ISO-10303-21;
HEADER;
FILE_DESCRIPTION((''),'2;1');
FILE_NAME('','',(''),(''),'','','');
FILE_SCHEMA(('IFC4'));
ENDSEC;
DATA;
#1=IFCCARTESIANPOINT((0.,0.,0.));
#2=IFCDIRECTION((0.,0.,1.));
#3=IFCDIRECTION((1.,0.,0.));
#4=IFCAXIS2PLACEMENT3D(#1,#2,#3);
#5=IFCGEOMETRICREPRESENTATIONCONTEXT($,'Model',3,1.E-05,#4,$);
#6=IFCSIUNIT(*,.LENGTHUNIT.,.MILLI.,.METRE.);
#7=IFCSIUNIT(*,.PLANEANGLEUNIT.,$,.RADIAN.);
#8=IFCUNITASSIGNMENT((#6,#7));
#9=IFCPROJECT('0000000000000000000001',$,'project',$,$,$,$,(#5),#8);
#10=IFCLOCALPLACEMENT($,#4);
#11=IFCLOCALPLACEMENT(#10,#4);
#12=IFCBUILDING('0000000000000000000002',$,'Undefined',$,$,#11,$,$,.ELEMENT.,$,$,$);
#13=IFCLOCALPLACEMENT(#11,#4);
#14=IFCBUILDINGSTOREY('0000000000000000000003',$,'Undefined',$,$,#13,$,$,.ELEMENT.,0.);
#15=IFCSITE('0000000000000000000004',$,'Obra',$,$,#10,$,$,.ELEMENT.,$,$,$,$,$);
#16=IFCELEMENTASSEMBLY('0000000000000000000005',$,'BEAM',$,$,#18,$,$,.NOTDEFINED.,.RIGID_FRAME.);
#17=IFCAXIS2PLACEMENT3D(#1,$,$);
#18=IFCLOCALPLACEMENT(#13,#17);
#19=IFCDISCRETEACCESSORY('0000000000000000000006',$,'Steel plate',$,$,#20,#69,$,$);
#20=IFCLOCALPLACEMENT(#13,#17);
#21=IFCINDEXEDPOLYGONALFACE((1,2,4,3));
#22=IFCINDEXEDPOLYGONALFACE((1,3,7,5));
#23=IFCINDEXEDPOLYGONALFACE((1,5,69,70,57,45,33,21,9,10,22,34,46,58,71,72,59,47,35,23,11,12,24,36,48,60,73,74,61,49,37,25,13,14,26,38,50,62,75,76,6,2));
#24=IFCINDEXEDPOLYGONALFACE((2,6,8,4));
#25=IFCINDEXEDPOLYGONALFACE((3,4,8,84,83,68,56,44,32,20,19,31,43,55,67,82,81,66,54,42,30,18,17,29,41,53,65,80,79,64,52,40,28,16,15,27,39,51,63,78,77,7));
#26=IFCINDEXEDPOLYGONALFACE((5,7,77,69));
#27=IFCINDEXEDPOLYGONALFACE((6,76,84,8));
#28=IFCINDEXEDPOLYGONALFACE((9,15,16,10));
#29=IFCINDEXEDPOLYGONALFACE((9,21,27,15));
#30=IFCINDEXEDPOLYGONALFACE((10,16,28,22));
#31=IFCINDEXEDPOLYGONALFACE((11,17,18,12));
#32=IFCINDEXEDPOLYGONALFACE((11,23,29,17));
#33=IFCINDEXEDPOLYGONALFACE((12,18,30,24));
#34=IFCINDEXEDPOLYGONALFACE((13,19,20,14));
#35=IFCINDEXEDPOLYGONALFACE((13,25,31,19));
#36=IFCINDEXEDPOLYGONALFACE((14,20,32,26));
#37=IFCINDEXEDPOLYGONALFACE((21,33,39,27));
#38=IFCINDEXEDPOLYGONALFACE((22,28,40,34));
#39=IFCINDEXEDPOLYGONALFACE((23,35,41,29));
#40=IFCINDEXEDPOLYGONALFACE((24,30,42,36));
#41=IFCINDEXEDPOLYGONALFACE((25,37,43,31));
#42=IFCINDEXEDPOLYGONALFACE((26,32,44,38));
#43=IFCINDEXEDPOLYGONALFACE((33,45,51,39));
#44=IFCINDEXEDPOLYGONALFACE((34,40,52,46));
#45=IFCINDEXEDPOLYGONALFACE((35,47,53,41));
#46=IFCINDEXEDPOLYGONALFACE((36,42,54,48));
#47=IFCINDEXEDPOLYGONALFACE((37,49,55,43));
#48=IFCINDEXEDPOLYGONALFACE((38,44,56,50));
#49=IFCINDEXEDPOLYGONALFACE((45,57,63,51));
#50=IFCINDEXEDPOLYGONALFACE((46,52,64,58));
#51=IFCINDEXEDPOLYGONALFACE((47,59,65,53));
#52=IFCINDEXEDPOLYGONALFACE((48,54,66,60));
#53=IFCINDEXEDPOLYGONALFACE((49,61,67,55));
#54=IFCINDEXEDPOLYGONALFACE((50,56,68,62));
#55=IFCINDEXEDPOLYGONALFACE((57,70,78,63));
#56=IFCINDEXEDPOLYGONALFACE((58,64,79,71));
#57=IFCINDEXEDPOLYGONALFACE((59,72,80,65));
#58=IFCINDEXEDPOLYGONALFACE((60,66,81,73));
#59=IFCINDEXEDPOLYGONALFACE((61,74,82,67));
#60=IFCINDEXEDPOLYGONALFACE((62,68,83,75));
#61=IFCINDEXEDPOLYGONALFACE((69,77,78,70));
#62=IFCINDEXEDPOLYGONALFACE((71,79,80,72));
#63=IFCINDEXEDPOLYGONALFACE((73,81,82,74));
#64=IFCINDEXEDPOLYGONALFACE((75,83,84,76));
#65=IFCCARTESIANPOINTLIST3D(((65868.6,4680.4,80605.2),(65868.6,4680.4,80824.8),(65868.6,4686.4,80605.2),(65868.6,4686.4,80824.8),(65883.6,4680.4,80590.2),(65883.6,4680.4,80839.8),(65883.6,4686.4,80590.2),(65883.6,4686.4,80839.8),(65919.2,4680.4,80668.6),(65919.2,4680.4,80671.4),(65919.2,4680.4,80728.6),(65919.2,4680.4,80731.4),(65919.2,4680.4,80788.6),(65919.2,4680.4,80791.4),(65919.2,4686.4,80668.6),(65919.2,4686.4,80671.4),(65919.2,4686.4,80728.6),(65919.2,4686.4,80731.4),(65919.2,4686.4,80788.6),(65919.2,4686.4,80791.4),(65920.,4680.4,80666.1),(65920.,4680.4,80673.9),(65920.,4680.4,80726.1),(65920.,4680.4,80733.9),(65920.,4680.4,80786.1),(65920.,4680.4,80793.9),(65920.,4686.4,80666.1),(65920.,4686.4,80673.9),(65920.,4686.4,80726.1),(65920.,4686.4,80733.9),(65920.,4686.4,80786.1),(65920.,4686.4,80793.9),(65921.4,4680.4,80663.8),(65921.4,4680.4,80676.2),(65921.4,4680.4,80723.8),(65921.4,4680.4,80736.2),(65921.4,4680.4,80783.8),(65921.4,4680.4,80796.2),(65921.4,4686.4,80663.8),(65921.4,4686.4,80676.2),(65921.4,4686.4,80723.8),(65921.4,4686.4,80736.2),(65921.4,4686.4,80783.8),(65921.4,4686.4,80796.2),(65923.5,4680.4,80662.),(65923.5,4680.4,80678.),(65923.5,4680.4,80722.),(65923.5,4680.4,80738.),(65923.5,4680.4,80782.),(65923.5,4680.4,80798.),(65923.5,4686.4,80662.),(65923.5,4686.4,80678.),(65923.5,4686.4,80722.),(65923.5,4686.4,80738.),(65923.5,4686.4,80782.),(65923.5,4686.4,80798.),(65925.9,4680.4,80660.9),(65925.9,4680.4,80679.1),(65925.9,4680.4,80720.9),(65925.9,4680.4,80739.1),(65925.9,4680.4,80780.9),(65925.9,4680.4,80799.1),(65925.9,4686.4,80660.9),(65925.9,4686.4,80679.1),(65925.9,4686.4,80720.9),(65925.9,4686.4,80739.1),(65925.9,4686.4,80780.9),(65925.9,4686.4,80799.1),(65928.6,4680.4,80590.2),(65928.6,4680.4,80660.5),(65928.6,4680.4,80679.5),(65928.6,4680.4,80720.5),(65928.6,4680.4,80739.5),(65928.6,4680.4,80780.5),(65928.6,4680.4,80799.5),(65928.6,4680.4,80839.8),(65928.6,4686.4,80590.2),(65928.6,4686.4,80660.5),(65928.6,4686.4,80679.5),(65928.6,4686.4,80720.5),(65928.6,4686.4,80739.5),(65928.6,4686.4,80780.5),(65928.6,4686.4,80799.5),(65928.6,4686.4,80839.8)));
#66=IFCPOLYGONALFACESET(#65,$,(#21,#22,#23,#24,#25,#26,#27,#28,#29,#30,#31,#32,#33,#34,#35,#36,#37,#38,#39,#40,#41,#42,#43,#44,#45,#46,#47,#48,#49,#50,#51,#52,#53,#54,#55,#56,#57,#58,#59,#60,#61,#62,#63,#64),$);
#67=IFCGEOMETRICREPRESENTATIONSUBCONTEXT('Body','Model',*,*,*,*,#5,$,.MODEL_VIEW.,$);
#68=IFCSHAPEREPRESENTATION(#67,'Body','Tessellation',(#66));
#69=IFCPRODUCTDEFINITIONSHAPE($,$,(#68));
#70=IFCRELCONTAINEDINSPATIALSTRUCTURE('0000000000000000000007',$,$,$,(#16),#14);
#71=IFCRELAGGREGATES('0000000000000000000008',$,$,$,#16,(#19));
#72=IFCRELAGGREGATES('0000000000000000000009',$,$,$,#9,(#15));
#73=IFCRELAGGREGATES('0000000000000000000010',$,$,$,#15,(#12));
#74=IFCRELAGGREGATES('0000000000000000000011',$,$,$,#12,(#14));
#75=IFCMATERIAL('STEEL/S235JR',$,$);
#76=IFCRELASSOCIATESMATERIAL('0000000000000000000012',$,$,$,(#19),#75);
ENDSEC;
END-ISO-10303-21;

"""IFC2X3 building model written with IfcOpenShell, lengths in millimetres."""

from ifc_helpers import new_model, si_unit, frame, origin_with_axes, origin_2d_with_axis, place, context, subcontext, project, spatial, polyline, circle, outline, extrude, source, transform, mapped, material, element, aggregate, save


model = new_model("IFC2X3")

# Units and contexts
model_context = context("Model", 3, precision=1e-05, world=origin_with_axes())
body_context = subcontext(model_context, "Body", "Model", "MODEL_VIEW")
ifc_project = project(units=[si_unit("LENGTHUNIT", "METRE", prefix="MILLI"), si_unit("PLANEANGLEUNIT", "RADIAN")], contexts=[model_context])

# Site, building, storey
site_placement = place(None, origin_with_axes())
site = spatial("IfcSite", under=ifc_project, at=site_placement, Name="Obra", CompositionType="ELEMENT")
building_placement = place(site_placement, origin_with_axes())
building = spatial("IfcBuilding", under=site, at=building_placement, Name="Undefined", CompositionType="ELEMENT")
storey_placement = place(building_placement, origin_with_axes())
storey = spatial("IfcBuildingStorey", under=building, at=storey_placement, Name="Undefined", CompositionType="ELEMENT", Elevation=0.0)

# Shared definitions
ifc_material = material(Name="STEEL/S235JR")

# Element assembly, discrete accessory, opening
assembly_1_placement = place(storey_placement, origin_with_axes())
assembly_1 = element("IfcElementAssembly", 1, at=assembly_1_placement, inside=storey, Name="BEAM", AssemblyPlace="NOTDEFINED", PredefinedType="RIGID_FRAME")
shared_shape_1 = source(origin_with_axes(), body_context, "Body", "SweptSolid", [
    extrude(circle(Radius=9.5, at=origin_2d_with_axis()), frame((0.0, -9.2, 0.0), z_axis=(0.0, 1.0, 0.0), x_axis=(1.0, 0.0, 0.0)), (0.0, 0.0, 1.0), 6.2),
])
discrete_accessory_1_placement = place(assembly_1_placement, frame((65928.6, 4683.4, 80590.2), z_axis=(0.0, 1.0, 0.0), x_axis=(-1.0, 0.0, 0.0)))
discrete_accessory_1 = element("IfcDiscreteAccessory", 2, at=discrete_accessory_1_placement, material=ifc_material, Name="Steel plate", context=body_context, shape_type="SweptSolid", body=[
    extrude(outline(polyline([(0.0, 0.0), (45.0, 0.0), (60.0, 15.0), (60.0, 234.6), (45.0, 249.6), (0.0, 249.6), (0.0, 0.0)])), frame((0.0, 0.0, -3.0), z_axis=(0.0, 0.0, 1.0), x_axis=(1.0, 0.0, 0.0)), (0.0, 0.0, 1.0), 6.0),
])
opening_1_placement = place(assembly_1_placement, frame((65878.6, 4689.5, 80850.0), z_axis=(1.0, 0.0, 0.0), x_axis=(0.0, 0.0, -1.0)))
element("IfcOpeningElement", 3, at=opening_1_placement, cuts=discrete_accessory_1, ObjectType="Opening", context=body_context, shape_type="MappedRepresentation", body=[
    mapped(shared_shape_1, transform((60.0, 0.0, 50.0))),
    mapped(shared_shape_1, transform((120.0, 0.0, 50.0))),
    mapped(shared_shape_1, transform((180.0, 0.0, 50.0))),
])
aggregate(assembly_1, [discrete_accessory_1])

save(model, "model.ifc")
